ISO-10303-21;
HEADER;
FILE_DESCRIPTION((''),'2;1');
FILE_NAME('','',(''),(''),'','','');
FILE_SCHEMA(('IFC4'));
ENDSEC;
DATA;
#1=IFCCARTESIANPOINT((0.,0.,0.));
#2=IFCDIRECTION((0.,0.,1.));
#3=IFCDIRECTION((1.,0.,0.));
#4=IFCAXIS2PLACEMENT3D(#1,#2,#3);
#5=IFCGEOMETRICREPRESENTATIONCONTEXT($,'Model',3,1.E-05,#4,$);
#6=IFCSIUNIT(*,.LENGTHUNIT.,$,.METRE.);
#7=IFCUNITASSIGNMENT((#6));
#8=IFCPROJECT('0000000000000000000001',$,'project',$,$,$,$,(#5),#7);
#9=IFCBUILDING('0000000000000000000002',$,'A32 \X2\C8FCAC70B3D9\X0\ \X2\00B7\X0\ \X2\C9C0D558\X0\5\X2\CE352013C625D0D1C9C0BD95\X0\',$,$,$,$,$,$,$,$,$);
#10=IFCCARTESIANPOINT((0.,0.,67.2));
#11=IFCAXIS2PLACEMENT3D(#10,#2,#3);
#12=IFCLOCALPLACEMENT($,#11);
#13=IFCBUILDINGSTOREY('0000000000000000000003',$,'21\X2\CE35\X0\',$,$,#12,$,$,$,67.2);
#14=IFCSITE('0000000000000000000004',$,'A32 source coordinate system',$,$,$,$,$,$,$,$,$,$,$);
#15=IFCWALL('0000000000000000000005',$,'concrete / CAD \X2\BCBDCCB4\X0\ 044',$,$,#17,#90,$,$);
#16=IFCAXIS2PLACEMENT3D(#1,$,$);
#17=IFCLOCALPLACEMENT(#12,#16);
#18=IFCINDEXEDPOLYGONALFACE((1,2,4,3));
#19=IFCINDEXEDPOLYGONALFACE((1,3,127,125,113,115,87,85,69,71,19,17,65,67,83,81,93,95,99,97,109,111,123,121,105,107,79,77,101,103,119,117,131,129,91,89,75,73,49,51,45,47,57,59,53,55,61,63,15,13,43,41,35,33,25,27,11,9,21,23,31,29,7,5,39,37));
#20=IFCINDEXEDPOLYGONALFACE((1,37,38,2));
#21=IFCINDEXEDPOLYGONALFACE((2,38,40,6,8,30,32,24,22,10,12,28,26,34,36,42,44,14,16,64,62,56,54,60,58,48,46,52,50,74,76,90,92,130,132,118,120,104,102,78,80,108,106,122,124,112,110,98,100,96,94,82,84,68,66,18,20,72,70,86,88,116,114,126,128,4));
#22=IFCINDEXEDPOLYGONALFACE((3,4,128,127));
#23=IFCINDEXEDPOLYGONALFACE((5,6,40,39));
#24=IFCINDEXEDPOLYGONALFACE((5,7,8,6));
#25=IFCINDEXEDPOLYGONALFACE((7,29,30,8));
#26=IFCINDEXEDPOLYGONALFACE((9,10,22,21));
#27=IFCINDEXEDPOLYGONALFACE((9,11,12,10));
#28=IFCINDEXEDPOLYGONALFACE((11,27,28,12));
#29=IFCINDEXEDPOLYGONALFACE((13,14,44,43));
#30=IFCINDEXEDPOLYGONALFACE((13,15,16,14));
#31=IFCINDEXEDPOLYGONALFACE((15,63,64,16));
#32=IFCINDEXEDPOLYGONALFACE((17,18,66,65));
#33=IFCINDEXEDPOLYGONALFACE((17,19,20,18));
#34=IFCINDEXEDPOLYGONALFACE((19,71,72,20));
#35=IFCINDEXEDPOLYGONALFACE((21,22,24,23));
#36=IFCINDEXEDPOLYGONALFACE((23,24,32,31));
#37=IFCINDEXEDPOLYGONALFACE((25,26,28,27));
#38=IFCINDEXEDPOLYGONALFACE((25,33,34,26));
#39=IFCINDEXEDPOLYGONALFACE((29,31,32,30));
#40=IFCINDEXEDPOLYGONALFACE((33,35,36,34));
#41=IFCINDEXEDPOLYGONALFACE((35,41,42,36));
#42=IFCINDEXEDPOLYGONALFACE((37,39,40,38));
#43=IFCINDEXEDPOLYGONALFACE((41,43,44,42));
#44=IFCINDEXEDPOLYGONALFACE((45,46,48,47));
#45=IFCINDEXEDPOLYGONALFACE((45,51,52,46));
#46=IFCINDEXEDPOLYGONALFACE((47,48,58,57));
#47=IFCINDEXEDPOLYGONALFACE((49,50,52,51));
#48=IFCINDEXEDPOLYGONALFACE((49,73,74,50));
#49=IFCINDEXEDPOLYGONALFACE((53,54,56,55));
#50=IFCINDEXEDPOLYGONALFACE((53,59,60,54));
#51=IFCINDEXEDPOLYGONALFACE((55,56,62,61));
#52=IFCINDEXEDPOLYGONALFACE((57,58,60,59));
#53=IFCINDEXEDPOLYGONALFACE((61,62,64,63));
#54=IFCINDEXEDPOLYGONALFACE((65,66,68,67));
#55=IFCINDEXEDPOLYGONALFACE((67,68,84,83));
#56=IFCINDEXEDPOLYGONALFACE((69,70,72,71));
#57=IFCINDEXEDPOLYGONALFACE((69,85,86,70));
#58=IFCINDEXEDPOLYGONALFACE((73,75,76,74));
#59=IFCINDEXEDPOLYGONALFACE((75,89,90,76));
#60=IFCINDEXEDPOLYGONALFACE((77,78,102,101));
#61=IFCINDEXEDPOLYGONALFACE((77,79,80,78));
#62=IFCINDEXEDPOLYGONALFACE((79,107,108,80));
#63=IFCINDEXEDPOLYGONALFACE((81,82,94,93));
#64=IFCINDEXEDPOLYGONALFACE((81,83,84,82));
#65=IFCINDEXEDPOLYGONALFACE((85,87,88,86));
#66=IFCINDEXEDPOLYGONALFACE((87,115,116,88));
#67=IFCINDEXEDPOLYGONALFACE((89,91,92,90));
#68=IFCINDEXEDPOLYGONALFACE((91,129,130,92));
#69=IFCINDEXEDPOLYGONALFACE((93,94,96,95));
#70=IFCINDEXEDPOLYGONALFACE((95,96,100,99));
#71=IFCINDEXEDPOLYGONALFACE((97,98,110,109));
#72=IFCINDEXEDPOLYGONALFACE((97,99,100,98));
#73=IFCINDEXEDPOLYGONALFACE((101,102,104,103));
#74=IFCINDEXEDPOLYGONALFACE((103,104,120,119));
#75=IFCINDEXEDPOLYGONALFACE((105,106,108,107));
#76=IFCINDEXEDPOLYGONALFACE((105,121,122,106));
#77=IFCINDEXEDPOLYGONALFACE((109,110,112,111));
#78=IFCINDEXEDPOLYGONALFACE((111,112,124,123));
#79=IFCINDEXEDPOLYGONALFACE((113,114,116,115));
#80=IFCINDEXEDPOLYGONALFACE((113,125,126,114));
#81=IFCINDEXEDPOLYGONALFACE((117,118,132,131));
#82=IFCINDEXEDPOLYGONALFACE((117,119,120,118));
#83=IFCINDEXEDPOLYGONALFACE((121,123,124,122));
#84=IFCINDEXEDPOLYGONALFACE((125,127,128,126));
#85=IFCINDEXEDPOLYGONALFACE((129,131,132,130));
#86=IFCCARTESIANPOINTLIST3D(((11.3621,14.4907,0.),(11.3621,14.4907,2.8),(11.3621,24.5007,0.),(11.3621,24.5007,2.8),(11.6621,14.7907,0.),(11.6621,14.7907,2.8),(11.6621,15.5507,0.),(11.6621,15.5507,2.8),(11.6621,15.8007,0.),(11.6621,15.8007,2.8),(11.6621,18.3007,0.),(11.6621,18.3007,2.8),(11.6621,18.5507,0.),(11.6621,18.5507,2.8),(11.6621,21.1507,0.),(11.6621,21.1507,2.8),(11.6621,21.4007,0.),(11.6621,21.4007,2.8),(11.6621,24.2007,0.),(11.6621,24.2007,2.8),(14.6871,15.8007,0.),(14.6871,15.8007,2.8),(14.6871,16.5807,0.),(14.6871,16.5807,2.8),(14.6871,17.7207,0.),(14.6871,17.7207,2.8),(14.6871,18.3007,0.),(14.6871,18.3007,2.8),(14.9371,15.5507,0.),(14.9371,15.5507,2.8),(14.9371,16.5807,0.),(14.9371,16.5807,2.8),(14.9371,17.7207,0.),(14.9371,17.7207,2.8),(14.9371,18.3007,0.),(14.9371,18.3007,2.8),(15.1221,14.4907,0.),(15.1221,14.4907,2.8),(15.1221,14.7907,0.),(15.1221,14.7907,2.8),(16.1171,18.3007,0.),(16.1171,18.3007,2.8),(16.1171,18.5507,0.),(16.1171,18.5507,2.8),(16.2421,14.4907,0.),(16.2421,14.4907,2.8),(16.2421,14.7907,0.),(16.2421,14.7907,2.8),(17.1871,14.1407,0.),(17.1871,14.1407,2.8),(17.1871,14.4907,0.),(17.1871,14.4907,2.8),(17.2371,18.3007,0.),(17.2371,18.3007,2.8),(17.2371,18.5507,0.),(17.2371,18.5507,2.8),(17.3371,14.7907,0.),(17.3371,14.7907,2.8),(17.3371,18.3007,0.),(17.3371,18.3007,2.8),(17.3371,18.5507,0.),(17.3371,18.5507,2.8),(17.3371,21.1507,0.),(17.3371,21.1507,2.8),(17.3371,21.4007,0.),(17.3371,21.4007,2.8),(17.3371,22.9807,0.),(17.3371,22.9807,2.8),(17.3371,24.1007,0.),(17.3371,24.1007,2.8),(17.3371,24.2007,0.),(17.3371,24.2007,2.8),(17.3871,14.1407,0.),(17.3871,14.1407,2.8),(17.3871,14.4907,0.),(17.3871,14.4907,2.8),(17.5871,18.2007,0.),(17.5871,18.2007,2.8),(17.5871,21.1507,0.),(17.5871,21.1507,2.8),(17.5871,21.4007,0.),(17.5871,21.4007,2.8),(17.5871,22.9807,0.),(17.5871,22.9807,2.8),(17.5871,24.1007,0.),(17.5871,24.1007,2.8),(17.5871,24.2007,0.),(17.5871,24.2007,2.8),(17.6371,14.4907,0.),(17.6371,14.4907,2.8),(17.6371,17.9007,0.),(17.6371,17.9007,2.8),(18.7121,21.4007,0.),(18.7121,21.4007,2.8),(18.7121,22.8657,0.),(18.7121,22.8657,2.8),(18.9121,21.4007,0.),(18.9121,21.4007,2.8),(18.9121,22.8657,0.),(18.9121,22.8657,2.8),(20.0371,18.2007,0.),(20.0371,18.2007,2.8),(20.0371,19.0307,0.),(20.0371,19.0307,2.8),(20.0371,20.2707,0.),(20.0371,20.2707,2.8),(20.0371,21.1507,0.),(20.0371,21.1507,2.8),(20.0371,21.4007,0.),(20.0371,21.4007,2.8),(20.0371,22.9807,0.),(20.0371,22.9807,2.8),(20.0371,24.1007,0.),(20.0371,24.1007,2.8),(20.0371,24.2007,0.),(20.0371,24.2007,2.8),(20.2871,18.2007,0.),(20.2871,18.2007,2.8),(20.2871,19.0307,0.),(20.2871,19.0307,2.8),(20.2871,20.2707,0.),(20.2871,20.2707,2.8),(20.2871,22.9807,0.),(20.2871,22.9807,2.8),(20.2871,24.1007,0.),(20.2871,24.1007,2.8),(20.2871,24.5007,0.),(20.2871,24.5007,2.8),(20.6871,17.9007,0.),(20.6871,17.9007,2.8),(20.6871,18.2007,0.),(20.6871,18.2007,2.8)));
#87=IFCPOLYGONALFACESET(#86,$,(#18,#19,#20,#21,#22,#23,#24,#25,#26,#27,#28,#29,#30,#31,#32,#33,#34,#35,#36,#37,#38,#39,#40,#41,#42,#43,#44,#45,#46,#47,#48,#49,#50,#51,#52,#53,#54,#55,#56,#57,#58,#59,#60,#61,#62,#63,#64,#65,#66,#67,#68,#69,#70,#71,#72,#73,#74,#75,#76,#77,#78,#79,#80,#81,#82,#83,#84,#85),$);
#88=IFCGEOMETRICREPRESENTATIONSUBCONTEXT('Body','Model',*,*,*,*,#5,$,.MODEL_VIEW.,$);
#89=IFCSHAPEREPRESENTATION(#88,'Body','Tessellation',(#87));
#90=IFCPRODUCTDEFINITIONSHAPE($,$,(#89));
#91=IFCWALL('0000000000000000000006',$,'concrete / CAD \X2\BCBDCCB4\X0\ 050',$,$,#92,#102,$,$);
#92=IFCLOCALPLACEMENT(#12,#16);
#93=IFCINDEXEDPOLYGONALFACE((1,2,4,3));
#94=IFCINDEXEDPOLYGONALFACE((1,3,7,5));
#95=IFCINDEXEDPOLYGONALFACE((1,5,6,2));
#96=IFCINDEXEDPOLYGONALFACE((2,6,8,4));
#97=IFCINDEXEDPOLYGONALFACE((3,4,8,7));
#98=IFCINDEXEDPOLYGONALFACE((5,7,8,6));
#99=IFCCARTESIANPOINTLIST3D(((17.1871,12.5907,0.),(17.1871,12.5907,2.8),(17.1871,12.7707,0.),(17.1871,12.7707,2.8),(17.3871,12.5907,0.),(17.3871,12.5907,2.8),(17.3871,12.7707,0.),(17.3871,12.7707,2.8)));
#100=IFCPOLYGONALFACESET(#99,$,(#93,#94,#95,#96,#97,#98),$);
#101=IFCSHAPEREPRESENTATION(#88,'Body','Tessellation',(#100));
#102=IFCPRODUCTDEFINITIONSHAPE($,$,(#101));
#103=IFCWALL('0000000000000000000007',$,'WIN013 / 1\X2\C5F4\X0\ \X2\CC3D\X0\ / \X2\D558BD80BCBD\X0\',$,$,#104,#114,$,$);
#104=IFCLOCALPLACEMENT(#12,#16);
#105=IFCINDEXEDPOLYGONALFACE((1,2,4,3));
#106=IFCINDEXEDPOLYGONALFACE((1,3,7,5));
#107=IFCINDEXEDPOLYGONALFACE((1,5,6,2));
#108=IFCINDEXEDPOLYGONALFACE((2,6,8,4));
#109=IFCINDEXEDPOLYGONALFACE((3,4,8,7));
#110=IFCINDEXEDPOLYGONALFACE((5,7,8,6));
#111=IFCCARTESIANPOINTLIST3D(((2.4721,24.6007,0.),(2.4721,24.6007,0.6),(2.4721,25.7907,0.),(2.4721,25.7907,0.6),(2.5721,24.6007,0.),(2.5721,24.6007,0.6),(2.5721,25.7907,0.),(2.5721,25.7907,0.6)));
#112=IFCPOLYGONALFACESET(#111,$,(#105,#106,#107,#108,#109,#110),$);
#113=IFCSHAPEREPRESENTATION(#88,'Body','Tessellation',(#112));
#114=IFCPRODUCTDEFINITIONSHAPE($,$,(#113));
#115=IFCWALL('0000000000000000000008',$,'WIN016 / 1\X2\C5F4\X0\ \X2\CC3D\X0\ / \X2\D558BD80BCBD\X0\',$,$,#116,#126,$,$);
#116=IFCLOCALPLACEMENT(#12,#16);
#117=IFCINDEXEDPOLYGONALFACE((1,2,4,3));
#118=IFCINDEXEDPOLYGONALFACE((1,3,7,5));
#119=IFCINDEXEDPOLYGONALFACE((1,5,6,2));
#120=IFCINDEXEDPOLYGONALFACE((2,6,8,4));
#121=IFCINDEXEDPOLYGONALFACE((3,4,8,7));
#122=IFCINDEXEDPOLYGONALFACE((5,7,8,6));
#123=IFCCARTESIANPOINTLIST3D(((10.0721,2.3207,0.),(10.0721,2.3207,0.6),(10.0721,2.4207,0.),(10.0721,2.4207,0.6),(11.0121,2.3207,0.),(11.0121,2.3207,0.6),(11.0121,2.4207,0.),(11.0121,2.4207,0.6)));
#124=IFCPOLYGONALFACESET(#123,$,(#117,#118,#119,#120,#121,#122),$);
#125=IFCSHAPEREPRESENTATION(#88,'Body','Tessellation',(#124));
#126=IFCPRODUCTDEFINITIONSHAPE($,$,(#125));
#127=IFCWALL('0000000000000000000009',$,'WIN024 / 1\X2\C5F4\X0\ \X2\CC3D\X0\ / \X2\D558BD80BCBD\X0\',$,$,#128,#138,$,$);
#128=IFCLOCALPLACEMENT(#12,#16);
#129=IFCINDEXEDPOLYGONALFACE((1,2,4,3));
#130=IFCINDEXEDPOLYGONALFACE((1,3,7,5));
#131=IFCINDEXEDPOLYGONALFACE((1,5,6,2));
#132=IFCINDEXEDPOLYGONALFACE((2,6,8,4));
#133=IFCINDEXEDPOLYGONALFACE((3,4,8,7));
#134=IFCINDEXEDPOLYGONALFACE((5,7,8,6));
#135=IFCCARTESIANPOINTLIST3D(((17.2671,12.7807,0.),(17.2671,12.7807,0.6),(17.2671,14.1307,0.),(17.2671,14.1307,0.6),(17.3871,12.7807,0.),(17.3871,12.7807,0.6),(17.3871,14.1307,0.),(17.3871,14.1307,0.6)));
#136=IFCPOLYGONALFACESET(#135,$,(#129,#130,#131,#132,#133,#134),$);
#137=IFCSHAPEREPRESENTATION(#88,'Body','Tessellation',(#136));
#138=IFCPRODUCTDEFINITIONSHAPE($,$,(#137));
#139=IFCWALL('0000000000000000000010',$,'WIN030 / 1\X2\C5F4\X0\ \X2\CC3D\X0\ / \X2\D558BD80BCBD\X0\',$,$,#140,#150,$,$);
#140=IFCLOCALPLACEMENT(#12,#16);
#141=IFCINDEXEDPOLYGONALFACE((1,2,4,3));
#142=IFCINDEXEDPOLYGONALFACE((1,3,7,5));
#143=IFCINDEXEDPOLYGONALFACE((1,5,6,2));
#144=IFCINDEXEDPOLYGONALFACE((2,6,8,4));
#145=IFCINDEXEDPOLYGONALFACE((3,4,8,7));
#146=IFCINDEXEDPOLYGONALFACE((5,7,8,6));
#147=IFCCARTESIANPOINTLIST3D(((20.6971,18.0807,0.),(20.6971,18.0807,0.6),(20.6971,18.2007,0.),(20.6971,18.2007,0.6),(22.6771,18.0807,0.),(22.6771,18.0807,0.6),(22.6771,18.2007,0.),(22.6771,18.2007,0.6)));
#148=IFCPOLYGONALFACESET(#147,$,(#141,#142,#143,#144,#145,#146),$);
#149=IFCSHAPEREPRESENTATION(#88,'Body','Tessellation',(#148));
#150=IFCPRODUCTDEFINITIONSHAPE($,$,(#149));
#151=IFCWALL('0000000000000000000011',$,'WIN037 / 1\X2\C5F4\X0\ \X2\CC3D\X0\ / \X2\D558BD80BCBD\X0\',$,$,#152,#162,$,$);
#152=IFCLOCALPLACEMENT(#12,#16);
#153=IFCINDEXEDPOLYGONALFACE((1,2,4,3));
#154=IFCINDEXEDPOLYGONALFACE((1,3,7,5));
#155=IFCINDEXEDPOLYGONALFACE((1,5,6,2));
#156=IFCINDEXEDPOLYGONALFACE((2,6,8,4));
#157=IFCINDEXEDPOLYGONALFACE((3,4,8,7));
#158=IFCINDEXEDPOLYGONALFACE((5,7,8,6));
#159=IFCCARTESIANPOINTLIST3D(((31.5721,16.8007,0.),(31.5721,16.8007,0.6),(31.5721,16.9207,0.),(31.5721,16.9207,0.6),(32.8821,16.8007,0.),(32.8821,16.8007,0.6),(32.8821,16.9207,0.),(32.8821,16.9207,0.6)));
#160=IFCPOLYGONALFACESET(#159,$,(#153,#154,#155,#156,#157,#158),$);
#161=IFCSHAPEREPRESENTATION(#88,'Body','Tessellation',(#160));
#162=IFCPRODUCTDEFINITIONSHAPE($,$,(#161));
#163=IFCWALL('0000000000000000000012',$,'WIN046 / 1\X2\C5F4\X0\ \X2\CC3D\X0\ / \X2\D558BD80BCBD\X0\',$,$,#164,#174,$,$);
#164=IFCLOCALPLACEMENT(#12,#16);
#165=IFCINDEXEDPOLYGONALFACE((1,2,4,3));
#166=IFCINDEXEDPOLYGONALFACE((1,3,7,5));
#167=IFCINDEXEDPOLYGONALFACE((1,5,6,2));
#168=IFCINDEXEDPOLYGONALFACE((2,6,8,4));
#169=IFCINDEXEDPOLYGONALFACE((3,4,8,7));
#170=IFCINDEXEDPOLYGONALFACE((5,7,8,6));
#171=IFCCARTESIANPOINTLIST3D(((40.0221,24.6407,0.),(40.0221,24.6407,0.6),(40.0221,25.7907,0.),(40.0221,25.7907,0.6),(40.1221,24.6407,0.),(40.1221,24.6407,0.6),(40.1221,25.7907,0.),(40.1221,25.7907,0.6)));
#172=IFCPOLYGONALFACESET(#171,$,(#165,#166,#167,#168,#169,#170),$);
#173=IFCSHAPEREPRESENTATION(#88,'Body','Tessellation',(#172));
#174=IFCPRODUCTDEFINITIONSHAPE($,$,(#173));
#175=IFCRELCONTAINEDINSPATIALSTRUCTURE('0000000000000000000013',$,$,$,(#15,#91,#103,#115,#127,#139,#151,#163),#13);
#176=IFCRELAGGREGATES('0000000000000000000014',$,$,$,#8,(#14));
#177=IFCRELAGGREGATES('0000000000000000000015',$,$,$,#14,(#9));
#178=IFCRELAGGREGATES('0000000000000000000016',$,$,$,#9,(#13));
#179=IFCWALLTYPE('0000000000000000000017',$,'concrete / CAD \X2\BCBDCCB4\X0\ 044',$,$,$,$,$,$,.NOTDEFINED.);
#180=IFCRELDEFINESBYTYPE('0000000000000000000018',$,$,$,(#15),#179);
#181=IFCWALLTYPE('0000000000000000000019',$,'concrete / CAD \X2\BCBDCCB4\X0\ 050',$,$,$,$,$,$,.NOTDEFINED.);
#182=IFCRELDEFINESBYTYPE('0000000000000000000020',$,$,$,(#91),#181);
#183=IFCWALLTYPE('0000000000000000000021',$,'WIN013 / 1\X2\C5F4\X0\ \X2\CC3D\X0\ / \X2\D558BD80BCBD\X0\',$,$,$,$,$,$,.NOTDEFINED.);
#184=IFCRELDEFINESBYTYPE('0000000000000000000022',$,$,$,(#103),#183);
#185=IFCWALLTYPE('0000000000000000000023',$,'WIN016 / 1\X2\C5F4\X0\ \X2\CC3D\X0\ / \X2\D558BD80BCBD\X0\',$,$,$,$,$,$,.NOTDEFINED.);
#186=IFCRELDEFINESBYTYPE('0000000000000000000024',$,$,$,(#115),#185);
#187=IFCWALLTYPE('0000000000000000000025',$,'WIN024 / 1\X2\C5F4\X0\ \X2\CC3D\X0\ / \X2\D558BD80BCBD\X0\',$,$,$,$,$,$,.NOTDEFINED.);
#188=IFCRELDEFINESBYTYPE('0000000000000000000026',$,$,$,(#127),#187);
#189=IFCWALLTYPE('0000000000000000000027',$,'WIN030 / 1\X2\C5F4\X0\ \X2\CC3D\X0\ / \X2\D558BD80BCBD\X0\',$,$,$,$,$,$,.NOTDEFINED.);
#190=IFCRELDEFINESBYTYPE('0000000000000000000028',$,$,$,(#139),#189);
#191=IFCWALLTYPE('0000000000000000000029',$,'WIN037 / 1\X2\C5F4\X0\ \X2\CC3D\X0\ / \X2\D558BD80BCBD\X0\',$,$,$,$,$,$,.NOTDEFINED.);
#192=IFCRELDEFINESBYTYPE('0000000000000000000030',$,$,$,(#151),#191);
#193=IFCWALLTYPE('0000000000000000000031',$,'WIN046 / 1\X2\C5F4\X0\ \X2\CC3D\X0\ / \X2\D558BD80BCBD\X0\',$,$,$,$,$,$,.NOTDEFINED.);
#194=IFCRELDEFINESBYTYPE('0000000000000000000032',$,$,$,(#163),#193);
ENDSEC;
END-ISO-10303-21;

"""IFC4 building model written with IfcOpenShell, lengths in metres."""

from ifc_helpers import new_model, si_unit, frame, origin, origin_with_axes, place, context, subcontext, project, spatial, polyline, outline, extrude, source, transform, mapped, type_object, type_shapes, element, save


model = new_model("IFC4")

# Units and contexts
model_context = context("Model", 3, precision=1e-05, world=origin_with_axes())
body_context = subcontext(model_context, "Body", "Model", "MODEL_VIEW")
ifc_project = project(units=[si_unit("LENGTHUNIT", "METRE")], contexts=[model_context])

# Site, building, storey
site = spatial("IfcSite", under=ifc_project, Name="A32 source coordinate system")
building = spatial("IfcBuilding", under=site, Name="A32 주거동 · 지하5층–옥탑지붕")
storey_placement = place(None, frame((0.0, 0.0, 67.2), z_axis=(0.0, 0.0, 1.0), x_axis=(1.0, 0.0, 0.0)))
storey = spatial("IfcBuildingStorey", under=building, at=storey_placement, Name="21층", Elevation=67.2)

# Walls
wall_type_1 = type_object("IfcWallType", Name="concrete / CAD 벽체 044", PredefinedType="NOTDEFINED")
shared_shape_1 = source(origin(), body_context, "Body", "SweptSolid", [
    extrude(outline(polyline([(17.3371, 21.4007), (17.3371, 22.9807), (17.5871, 22.9807), (17.5871, 21.4007), (18.7121, 21.4007), (18.7121, 22.8657), (18.9121, 22.8657), (18.9121, 21.4007), (20.0371, 21.4007), (20.0371, 22.9807), (20.2871, 22.9807), (20.2871, 20.2707), (20.0371, 20.2707), (20.0371, 21.1507), (17.5871, 21.1507), (17.5871, 18.2007), (20.0371, 18.2007), (20.0371, 19.0307), (20.2871, 19.0307), (20.2871, 18.2007), (20.6871, 18.2007), (20.6871, 17.9007), (17.6371, 17.9007), (17.6371, 14.4907), (17.3871, 14.4907), (17.3871, 14.1407), (17.1871, 14.1407), (17.1871, 14.4907), (16.2421, 14.4907), (16.2421, 14.7907), (17.3371, 14.7907), (17.3371, 18.3007), (17.2371, 18.3007), (17.2371, 18.5507), (17.3371, 18.5507), (17.3371, 21.1507), (11.6621, 21.1507), (11.6621, 18.5507), (16.1171, 18.5507), (16.1171, 18.3007), (14.9371, 18.3007), (14.9371, 17.7207), (14.6871, 17.7207), (14.6871, 18.3007), (11.6621, 18.3007), (11.6621, 15.8007), (14.6871, 15.8007), (14.6871, 16.5807), (14.9371, 16.5807), (14.9371, 15.5507), (11.6621, 15.5507), (11.6621, 14.7907), (15.1221, 14.7907), (15.1221, 14.4907), (11.3621, 14.4907), (11.3621, 24.5007), (20.2871, 24.5007), (20.2871, 24.1007), (20.0371, 24.1007), (20.0371, 24.2007), (17.5871, 24.2007), (17.5871, 24.1007), (17.3371, 24.1007), (17.3371, 24.2007), (11.6621, 24.2007), (11.6621, 21.4007), (17.3371, 21.4007)])), origin(), (0.0, 0.0, 1.0), 2.8),
])
type_shapes(wall_type_1, [shared_shape_1])
wall_1_placement = place(storey_placement, origin_with_axes())
element("IfcWall", 1, at=wall_1_placement, inside=storey, type_object=wall_type_1, Name="concrete / CAD 벽체 044", context=body_context, shape_type="MappedRepresentation", body=[
    mapped(shared_shape_1, transform((0.0, 0.0, 0.0), scale=1.0)),
])
wall_type_2 = type_object("IfcWallType", Name="concrete / CAD 벽체 050", PredefinedType="NOTDEFINED")
shared_shape_2 = source(origin(), body_context, "Body", "SweptSolid", [
    extrude(outline(polyline([(17.3871, 12.5907), (17.1871, 12.5907), (17.1871, 12.7707), (17.3871, 12.7707), (17.3871, 12.5907)])), origin(), (0.0, 0.0, 1.0), 2.8),
])
type_shapes(wall_type_2, [shared_shape_2])
wall_2_placement = place(storey_placement, origin_with_axes())
element("IfcWall", 2, at=wall_2_placement, inside=storey, type_object=wall_type_2, Name="concrete / CAD 벽체 050", context=body_context, shape_type="MappedRepresentation", body=[
    mapped(shared_shape_2, transform((0.0, 0.0, 0.0), scale=1.0)),
])
wall_type_3 = type_object("IfcWallType", Name="WIN013 / 1열 창 / 하부벽", PredefinedType="NOTDEFINED")
shared_shape_3 = source(origin(), body_context, "Body", "SweptSolid", [
    extrude(outline(polyline([(2.5721, 25.7907), (2.5721, 24.6007), (2.4721, 24.6007), (2.4721, 25.7907), (2.5721, 25.7907)])), origin(), (0.0, 0.0, 1.0), 0.6),
])
type_shapes(wall_type_3, [shared_shape_3])
wall_3_placement = place(storey_placement, origin_with_axes())
element("IfcWall", 3, at=wall_3_placement, inside=storey, type_object=wall_type_3, Name="WIN013 / 1열 창 / 하부벽", context=body_context, shape_type="MappedRepresentation", body=[
    mapped(shared_shape_3, transform((0.0, 0.0, 0.0), scale=1.0)),
])
wall_type_4 = type_object("IfcWallType", Name="WIN016 / 1열 창 / 하부벽", PredefinedType="NOTDEFINED")
shared_shape_4 = source(origin(), body_context, "Body", "SweptSolid", [
    extrude(outline(polyline([(11.0121, 2.4207), (11.0121, 2.3207), (10.0721, 2.3207), (10.0721, 2.4207), (11.0121, 2.4207)])), origin(), (0.0, 0.0, 1.0), 0.6),
])
type_shapes(wall_type_4, [shared_shape_4])
wall_4_placement = place(storey_placement, origin_with_axes())
element("IfcWall", 4, at=wall_4_placement, inside=storey, type_object=wall_type_4, Name="WIN016 / 1열 창 / 하부벽", context=body_context, shape_type="MappedRepresentation", body=[
    mapped(shared_shape_4, transform((0.0, 0.0, 0.0), scale=1.0)),
])
wall_type_5 = type_object("IfcWallType", Name="WIN024 / 1열 창 / 하부벽", PredefinedType="NOTDEFINED")
shared_shape_5 = source(origin(), body_context, "Body", "SweptSolid", [
    extrude(outline(polyline([(17.3871, 14.1307), (17.3871, 12.7807), (17.2671, 12.7807), (17.2671, 14.1307), (17.3871, 14.1307)])), origin(), (0.0, 0.0, 1.0), 0.6),
])
type_shapes(wall_type_5, [shared_shape_5])
wall_5_placement = place(storey_placement, origin_with_axes())
element("IfcWall", 5, at=wall_5_placement, inside=storey, type_object=wall_type_5, Name="WIN024 / 1열 창 / 하부벽", context=body_context, shape_type="MappedRepresentation", body=[
    mapped(shared_shape_5, transform((0.0, 0.0, 0.0), scale=1.0)),
])
wall_type_6 = type_object("IfcWallType", Name="WIN030 / 1열 창 / 하부벽", PredefinedType="NOTDEFINED")
shared_shape_6 = source(origin(), body_context, "Body", "SweptSolid", [
    extrude(outline(polyline([(22.6771, 18.2007), (22.6771, 18.0807), (20.6971, 18.0807), (20.6971, 18.2007), (22.6771, 18.2007)])), origin(), (0.0, 0.0, 1.0), 0.6),
])
type_shapes(wall_type_6, [shared_shape_6])
wall_6_placement = place(storey_placement, origin_with_axes())
element("IfcWall", 6, at=wall_6_placement, inside=storey, type_object=wall_type_6, Name="WIN030 / 1열 창 / 하부벽", context=body_context, shape_type="MappedRepresentation", body=[
    mapped(shared_shape_6, transform((0.0, 0.0, 0.0), scale=1.0)),
])
wall_type_7 = type_object("IfcWallType", Name="WIN037 / 1열 창 / 하부벽", PredefinedType="NOTDEFINED")
shared_shape_7 = source(origin(), body_context, "Body", "SweptSolid", [
    extrude(outline(polyline([(32.8821, 16.9207), (32.8821, 16.8007), (31.5721, 16.8007), (31.5721, 16.9207), (32.8821, 16.9207)])), origin(), (0.0, 0.0, 1.0), 0.6),
])
type_shapes(wall_type_7, [shared_shape_7])
wall_7_placement = place(storey_placement, origin_with_axes())
element("IfcWall", 7, at=wall_7_placement, inside=storey, type_object=wall_type_7, Name="WIN037 / 1열 창 / 하부벽", context=body_context, shape_type="MappedRepresentation", body=[
    mapped(shared_shape_7, transform((0.0, 0.0, 0.0), scale=1.0)),
])
wall_type_8 = type_object("IfcWallType", Name="WIN046 / 1열 창 / 하부벽", PredefinedType="NOTDEFINED")
shared_shape_8 = source(origin(), body_context, "Body", "SweptSolid", [
    extrude(outline(polyline([(40.1221, 25.7907), (40.1221, 24.6407), (40.0221, 24.6407), (40.0221, 25.7907), (40.1221, 25.7907)])), origin(), (0.0, 0.0, 1.0), 0.6),
])
type_shapes(wall_type_8, [shared_shape_8])
wall_8_placement = place(storey_placement, origin_with_axes())
element("IfcWall", 8, at=wall_8_placement, inside=storey, type_object=wall_type_8, Name="WIN046 / 1열 창 / 하부벽", context=body_context, shape_type="MappedRepresentation", body=[
    mapped(shared_shape_8, transform((0.0, 0.0, 0.0), scale=1.0)),
])

save(model, "model.ifc")
